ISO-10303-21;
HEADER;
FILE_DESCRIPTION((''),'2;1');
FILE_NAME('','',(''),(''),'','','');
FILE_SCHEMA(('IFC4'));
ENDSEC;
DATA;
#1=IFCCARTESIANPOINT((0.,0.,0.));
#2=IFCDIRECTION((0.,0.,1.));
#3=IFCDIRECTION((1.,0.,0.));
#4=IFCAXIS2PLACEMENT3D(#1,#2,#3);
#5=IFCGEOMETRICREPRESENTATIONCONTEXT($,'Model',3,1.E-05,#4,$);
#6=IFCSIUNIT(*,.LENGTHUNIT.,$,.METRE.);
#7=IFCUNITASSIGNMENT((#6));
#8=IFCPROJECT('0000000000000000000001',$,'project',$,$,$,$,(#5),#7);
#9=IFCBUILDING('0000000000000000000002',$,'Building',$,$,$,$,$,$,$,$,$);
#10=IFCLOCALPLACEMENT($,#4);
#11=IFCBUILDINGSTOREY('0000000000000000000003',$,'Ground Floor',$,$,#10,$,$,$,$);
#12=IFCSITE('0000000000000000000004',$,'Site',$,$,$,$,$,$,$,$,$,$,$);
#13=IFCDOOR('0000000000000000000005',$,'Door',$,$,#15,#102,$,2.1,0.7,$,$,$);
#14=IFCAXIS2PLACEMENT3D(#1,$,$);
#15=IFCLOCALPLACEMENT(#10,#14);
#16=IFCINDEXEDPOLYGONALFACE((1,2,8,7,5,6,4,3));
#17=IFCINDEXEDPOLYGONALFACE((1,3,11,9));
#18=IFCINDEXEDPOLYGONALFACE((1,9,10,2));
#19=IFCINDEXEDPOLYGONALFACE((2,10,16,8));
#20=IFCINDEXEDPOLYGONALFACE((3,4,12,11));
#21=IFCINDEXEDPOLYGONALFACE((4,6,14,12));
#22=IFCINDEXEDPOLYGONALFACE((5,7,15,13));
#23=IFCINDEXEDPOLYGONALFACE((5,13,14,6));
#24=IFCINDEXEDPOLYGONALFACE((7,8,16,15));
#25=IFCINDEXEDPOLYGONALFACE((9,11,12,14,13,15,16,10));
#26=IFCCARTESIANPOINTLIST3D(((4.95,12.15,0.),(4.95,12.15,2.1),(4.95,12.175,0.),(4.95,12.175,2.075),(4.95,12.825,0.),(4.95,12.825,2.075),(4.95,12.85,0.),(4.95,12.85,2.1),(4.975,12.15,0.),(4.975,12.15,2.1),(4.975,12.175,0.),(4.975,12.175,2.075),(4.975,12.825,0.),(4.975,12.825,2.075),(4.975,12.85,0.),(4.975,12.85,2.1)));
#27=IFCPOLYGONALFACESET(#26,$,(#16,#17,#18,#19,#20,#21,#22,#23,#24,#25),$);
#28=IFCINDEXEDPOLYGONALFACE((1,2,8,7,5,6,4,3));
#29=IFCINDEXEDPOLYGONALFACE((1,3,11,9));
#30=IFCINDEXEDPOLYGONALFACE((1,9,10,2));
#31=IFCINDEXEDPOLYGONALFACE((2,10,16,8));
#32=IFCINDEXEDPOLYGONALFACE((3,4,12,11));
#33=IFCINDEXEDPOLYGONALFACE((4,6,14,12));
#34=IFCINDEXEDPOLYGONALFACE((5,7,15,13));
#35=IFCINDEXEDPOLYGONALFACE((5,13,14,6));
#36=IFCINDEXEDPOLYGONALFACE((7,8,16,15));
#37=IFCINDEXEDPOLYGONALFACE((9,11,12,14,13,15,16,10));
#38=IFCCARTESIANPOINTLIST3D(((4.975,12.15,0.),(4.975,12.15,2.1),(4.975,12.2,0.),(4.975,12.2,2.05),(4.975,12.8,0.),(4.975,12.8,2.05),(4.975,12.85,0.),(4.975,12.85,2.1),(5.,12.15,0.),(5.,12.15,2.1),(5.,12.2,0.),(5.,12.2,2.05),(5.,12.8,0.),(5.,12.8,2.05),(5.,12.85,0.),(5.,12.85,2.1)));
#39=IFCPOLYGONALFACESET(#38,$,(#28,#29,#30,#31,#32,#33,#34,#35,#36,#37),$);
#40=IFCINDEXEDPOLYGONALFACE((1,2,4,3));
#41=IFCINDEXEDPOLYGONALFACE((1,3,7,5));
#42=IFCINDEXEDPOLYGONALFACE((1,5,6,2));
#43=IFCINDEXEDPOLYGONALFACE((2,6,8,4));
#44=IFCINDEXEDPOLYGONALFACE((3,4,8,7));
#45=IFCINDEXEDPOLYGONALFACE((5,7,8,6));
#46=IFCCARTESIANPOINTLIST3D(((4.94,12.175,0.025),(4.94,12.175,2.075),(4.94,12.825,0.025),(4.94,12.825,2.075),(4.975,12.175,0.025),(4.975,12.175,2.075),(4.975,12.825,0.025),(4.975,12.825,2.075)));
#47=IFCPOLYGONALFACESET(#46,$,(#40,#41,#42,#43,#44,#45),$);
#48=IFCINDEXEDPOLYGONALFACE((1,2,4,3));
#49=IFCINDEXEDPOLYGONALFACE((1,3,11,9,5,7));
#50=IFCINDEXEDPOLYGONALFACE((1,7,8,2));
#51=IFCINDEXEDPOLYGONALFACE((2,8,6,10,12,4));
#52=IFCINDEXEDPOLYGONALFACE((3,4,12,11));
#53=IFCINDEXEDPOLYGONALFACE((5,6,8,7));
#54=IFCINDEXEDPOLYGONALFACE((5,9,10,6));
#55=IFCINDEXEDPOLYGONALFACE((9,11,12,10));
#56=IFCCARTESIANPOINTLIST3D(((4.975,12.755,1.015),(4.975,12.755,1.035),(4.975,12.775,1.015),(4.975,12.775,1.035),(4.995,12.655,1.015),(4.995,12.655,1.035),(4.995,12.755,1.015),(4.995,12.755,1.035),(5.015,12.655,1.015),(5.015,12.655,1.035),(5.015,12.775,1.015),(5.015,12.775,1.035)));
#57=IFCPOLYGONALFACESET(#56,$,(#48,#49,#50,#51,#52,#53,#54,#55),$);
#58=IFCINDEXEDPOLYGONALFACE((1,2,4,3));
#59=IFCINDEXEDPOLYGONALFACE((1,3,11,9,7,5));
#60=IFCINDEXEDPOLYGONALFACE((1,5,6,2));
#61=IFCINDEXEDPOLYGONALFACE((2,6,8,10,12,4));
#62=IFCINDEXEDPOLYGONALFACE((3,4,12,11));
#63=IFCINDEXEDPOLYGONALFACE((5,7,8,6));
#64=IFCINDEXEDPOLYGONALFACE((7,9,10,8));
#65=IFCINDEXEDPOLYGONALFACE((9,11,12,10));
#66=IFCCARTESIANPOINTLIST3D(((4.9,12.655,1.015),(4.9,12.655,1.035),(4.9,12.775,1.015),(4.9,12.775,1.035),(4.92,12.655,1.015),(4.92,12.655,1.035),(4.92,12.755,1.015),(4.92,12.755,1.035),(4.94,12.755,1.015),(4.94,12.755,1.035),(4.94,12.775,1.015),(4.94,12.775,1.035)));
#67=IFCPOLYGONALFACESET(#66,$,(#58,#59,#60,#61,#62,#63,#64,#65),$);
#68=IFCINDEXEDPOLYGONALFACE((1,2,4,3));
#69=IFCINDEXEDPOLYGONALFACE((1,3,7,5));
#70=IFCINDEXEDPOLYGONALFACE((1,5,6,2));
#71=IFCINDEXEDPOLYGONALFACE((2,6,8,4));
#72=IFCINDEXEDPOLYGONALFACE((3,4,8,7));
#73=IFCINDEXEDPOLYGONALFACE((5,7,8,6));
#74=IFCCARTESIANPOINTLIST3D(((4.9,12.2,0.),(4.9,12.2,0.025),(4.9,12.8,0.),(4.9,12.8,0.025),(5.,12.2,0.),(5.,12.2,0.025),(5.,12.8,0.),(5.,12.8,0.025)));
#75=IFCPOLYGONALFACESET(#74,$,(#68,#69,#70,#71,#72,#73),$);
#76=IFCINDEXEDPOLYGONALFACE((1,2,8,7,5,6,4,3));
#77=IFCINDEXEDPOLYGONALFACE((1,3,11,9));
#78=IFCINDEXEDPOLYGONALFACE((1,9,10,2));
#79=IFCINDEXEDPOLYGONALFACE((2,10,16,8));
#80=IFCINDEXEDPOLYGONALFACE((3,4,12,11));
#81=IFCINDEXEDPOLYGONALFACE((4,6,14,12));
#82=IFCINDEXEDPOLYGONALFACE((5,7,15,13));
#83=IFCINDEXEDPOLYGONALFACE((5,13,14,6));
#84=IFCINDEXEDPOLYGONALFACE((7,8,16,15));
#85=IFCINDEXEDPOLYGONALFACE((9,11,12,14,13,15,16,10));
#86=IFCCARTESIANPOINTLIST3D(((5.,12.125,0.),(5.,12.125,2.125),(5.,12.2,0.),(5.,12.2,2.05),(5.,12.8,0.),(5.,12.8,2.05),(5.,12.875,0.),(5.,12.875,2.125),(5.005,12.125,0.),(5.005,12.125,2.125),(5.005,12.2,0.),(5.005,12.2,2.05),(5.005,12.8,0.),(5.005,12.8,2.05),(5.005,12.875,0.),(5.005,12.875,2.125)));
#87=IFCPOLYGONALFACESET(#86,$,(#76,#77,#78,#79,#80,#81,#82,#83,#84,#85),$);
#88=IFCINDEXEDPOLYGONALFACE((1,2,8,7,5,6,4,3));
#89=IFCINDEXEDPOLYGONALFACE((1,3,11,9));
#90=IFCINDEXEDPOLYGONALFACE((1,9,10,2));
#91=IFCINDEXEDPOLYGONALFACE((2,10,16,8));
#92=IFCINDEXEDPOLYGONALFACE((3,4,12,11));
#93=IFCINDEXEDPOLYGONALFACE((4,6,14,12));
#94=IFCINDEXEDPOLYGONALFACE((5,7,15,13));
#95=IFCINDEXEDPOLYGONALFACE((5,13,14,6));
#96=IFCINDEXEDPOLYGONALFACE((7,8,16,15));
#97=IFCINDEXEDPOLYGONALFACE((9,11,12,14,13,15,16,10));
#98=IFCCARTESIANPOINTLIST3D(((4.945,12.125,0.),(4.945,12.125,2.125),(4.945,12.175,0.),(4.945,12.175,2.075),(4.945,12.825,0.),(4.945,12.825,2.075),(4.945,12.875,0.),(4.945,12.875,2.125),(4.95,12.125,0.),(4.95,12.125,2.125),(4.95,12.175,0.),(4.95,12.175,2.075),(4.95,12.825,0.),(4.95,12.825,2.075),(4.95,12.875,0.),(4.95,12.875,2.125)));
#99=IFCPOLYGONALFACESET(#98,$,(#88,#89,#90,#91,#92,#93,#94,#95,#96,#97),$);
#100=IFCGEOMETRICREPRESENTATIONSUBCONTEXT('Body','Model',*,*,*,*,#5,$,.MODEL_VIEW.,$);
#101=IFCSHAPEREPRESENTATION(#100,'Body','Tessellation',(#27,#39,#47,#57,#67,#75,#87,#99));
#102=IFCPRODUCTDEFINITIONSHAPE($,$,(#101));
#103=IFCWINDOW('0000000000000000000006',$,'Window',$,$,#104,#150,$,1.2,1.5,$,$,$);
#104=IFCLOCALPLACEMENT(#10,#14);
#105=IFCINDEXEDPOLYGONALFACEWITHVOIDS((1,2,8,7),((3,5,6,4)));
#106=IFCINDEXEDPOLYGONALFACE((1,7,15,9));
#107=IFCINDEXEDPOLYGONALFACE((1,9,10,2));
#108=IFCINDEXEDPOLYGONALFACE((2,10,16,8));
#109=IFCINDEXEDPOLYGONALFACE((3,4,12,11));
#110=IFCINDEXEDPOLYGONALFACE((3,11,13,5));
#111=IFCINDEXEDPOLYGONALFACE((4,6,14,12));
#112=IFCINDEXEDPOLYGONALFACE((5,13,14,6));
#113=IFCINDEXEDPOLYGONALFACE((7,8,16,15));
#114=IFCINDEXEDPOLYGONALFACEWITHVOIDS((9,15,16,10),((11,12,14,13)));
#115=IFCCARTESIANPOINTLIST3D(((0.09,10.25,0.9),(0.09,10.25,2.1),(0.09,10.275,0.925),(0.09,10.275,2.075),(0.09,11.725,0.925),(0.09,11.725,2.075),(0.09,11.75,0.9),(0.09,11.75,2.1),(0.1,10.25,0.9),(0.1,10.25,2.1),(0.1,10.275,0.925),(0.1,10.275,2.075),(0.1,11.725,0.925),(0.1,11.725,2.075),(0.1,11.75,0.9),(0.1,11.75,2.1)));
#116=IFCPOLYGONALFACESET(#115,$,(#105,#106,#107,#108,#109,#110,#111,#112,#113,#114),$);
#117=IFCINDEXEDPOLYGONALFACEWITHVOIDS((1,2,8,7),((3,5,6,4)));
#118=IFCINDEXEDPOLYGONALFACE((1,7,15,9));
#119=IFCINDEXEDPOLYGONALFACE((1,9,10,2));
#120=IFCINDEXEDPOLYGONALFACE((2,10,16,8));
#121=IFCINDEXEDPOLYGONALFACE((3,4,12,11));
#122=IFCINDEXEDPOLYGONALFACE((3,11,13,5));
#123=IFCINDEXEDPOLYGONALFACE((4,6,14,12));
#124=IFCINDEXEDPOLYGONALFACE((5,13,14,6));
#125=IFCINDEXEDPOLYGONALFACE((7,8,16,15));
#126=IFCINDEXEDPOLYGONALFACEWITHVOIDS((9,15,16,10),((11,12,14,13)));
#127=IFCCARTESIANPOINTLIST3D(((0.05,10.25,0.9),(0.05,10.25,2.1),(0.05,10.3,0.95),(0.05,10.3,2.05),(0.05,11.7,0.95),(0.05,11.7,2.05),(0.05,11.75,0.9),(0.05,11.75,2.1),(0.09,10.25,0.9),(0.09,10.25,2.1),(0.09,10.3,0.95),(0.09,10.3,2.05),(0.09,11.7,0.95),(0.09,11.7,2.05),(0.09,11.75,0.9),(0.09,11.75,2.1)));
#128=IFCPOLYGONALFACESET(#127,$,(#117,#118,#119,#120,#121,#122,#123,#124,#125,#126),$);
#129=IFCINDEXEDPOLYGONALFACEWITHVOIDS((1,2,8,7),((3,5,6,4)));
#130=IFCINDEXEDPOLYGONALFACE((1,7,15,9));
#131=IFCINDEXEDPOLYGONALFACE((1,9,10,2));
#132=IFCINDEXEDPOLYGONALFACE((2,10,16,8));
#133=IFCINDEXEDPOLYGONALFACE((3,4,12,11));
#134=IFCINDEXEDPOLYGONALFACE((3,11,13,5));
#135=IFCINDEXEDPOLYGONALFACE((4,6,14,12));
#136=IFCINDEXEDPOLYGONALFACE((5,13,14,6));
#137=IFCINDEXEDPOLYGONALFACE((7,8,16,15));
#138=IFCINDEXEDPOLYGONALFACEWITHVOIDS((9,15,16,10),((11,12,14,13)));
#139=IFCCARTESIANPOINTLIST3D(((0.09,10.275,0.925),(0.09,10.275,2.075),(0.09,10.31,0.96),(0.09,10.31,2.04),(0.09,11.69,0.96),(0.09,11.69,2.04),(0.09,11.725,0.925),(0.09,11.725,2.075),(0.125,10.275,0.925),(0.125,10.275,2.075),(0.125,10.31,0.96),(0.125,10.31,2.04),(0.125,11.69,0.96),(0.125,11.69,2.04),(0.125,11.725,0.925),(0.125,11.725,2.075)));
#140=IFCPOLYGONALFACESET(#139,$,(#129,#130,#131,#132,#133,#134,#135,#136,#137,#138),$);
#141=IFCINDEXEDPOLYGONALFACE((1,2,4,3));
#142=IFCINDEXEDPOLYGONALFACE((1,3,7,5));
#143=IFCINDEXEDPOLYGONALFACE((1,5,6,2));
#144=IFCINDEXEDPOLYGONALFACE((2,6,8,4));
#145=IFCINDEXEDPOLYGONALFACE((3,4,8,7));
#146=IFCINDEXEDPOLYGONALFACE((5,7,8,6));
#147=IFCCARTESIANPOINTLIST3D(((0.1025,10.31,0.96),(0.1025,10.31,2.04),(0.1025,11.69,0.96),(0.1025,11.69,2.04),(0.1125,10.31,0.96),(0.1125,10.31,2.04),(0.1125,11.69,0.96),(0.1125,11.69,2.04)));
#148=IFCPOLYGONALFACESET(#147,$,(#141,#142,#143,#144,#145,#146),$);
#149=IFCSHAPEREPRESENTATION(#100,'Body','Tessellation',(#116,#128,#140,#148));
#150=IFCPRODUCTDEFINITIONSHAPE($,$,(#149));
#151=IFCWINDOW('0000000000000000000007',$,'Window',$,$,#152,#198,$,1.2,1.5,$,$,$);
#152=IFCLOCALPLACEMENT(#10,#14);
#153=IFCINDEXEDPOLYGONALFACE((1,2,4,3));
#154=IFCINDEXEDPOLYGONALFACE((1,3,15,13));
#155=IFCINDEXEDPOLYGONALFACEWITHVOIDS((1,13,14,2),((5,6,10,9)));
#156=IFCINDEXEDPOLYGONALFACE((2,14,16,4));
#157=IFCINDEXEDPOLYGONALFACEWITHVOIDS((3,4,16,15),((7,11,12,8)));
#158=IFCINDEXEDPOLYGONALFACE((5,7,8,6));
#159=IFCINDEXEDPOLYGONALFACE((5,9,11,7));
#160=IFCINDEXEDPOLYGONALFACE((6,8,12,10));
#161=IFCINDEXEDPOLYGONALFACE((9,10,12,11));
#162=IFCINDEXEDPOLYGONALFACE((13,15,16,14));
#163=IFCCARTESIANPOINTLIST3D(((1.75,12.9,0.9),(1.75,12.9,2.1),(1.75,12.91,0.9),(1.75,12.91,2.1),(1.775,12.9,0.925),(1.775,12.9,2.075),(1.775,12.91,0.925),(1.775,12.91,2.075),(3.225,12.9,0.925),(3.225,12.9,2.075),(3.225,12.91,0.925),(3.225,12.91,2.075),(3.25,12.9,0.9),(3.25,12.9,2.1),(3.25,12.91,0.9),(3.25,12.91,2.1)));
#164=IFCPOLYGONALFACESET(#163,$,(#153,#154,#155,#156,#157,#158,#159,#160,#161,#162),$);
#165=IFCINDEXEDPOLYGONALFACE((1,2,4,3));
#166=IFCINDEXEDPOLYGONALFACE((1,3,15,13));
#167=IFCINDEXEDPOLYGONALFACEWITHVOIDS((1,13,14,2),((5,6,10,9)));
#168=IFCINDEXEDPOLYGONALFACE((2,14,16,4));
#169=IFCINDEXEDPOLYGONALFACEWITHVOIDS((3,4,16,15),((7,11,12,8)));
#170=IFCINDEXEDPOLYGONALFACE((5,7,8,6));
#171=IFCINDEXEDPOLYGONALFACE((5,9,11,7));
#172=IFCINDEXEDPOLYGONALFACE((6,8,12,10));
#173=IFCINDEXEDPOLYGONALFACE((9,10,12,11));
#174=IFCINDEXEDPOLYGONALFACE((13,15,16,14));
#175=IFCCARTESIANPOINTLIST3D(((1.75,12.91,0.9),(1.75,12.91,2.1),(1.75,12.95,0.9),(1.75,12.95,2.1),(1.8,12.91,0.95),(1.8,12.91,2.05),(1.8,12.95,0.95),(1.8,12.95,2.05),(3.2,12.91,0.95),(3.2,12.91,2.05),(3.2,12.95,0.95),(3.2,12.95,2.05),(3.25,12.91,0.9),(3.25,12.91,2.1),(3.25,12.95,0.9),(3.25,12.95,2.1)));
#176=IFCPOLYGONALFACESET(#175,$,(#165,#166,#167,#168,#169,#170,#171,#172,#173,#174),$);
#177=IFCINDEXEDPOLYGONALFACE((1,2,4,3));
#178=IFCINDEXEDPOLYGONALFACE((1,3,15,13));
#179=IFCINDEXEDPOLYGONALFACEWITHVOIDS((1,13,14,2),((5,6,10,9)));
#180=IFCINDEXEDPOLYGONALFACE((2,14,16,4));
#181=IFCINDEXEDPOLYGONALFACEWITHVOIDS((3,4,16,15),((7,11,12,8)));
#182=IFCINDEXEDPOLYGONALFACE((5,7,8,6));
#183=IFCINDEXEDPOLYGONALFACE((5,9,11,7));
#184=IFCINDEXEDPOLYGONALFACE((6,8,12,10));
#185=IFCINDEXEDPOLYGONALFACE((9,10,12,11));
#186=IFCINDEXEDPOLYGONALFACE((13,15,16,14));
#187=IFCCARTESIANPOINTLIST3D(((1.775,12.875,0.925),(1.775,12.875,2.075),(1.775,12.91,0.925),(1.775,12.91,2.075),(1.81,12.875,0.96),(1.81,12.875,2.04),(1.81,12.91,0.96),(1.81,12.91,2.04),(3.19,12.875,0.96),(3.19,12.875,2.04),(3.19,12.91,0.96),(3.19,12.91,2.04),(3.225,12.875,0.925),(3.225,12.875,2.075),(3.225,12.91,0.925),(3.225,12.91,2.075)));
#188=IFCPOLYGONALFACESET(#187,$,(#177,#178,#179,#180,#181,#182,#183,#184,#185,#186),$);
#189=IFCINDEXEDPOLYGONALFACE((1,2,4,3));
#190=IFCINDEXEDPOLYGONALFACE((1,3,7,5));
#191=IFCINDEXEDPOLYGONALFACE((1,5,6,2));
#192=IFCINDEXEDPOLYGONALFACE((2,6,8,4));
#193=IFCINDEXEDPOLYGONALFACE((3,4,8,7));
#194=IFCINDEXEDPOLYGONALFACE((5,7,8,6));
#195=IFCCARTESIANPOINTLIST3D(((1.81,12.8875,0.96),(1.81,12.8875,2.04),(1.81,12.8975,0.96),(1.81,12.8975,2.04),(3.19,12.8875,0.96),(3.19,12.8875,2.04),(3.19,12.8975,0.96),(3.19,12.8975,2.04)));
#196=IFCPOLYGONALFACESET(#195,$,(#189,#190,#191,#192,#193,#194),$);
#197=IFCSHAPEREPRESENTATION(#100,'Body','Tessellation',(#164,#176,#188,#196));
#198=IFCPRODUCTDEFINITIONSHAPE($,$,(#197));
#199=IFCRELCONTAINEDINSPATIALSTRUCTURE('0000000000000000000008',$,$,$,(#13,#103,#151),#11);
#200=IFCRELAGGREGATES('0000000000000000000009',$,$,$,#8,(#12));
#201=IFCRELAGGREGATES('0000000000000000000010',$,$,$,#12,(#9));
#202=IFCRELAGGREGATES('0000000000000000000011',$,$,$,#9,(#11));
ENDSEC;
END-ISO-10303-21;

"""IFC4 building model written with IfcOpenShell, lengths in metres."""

from ifc_helpers import new_model, si_unit, frame, origin_with_axes, place, context, subcontext, project, spatial, line, indexed_curve, outline, extrude, element, save


model = new_model("IFC4")

# Units and contexts
model_context = context("Model", 3, precision=1e-05, world=origin_with_axes())
body_context = subcontext(model_context, "Body", "Model", "MODEL_VIEW")
ifc_project = project(units=[si_unit("LENGTHUNIT", "METRE")], contexts=[model_context])

# Site, building, storey
site = spatial("IfcSite", under=ifc_project, Name="Site")
building = spatial("IfcBuilding", under=site, Name="Building")
storey_placement = place(None, origin_with_axes())
storey = spatial("IfcBuildingStorey", under=building, at=storey_placement, Name="Ground Floor")

# Door
door_1_placement = place(storey_placement, frame((5.0, 12.15, 0.0), z_axis=(0.0, 0.0, 1.0), x_axis=(0.0, 1.0, 0.0)))
element("IfcDoor", 1, at=door_1_placement, inside=storey, Name="Door", OverallHeight=2.1, OverallWidth=0.7, context=body_context, shape_type="SweptSolid", body=[
    extrude(outline(indexed_curve([(0.0, 0.0), (0.0, 2.1), (0.7, 2.1), (0.7, 0.0), (0.675, 0.0), (0.675, 2.075), (0.025, 2.075), (0.025, 0.0)], segments=[line(1, 2, 3, 4, 5, 6, 7, 8, 1)])), frame((0.0, 0.025, 0.0), z_axis=(0.0, -1.0, 0.0), x_axis=(1.0, 0.0, 0.0)), (0.0, 0.0, -1.0), 0.025),
    extrude(outline(indexed_curve([(0.0, 0.0), (0.0, 2.1), (0.7, 2.1), (0.7, 0.0), (0.65, 0.0), (0.65, 2.05), (0.05, 2.05), (0.05, 0.0)], segments=[line(1, 2, 3, 4, 5, 6, 7, 8, 1)])), frame((0.0, 0.0, 0.0), z_axis=(0.0, -1.0, 0.0), x_axis=(1.0, 0.0, 0.0)), (0.0, 0.0, -1.0), 0.025),
    extrude(outline(indexed_curve([(0.0, 0.0), (0.65, 0.0), (0.65, 0.035), (0.0, 0.035)], segments=[line(1, 2, 3, 4, 1)])), frame((0.025, 0.025, 0.025), z_axis=(0.0, 0.0, 1.0), x_axis=(1.0, 0.0, 0.0)), (0.0, 0.0, 1.0), 2.05),
    extrude(outline(indexed_curve([(0.0, 0.0), (0.0, -0.04), (-0.12, -0.04), (-0.12, -0.02), (-0.02, -0.02), (-0.02, 0.0)], segments=[line(1, 2, 3, 4, 5, 6, 1)])), frame((0.625, 0.025, 1.015), z_axis=(0.0, 0.0, 1.0), x_axis=(1.0, 0.0, 0.0)), (0.0, 0.0, 1.0), 0.02),
    extrude(outline(indexed_curve([(0.0, 0.0), (0.0, 0.04), (-0.12, 0.04), (-0.12, 0.02), (-0.02, 0.02), (-0.02, 0.0)], segments=[line(1, 2, 3, 4, 5, 6, 1)])), frame((0.625, 0.06, 1.015), z_axis=(0.0, 0.0, 1.0), x_axis=(1.0, 0.0, 0.0)), (0.0, 0.0, 1.0), 0.02),
    extrude(outline(indexed_curve([(0.0, 0.0), (0.6, 0.0), (0.6, 0.1), (0.0, 0.1)], segments=[line(1, 2, 3, 4, 1)])), frame((0.05, 0.0, 0.0), z_axis=(0.0, 0.0, 1.0), x_axis=(1.0, 0.0, 0.0)), (0.0, 0.0, 1.0), 0.025),
    extrude(outline(indexed_curve([(0.0, 0.0), (0.0, 2.125), (0.75, 2.125), (0.75, 0.0), (0.675, 0.0), (0.675, 2.05), (0.075, 2.05), (0.075, 0.0)], segments=[line(1, 2, 3, 4, 5, 6, 7, 8, 1)])), frame((-0.025, -0.005, 0.0), z_axis=(0.0, -1.0, 0.0), x_axis=(1.0, 0.0, 0.0)), (0.0, 0.0, -1.0), 0.005),
    extrude(outline(indexed_curve([(0.0, 0.0), (0.0, 2.125), (0.75, 2.125), (0.75, 0.0), (0.7, 0.0), (0.7, 2.075), (0.05, 2.075), (0.05, 0.0)], segments=[line(1, 2, 3, 4, 5, 6, 7, 8, 1)])), frame((-0.025, 0.05, 0.0), z_axis=(0.0, -1.0, 0.0), x_axis=(1.0, 0.0, 0.0)), (0.0, 0.0, -1.0), 0.005),
])

# Windows
for number, where, z_axis, x_axis, name in (
    (2, (0.0, 11.75, 0.9), (0.0, 0.0, 1.0), (0.0, -1.0, 0.0), "Window"),
    (3, (3.25, 13.0, 0.9), (0.0, 0.0, 1.0), (-1.0, 0.0, 0.0), "Window"),
):
    element("IfcWindow", number, at=place(storey_placement, frame(where, z_axis=z_axis, x_axis=x_axis)), inside=storey, Name=name, OverallHeight=1.2, OverallWidth=1.5, context=body_context, shape_type="SweptSolid", body=[
        extrude(outline(indexed_curve([(0.0, 0.0), (1.5, 0.0), (1.5, 1.2), (0.0, 1.2)], segments=[line(1, 2, 3, 4, 1)]), holes=[indexed_curve([(0.025, 0.025), (1.475, 0.025), (1.475, 1.175), (0.025, 1.175)], segments=[line(1, 2, 3, 4, 1)])]), frame((0.0, 0.09, 0.0), z_axis=(0.0, -1.0, 0.0), x_axis=(1.0, 0.0, 0.0)), (0.0, 0.0, -1.0), 0.01),
        extrude(outline(indexed_curve([(0.0, 0.0), (1.5, 0.0), (1.5, 1.2), (0.0, 1.2)], segments=[line(1, 2, 3, 4, 1)]), holes=[indexed_curve([(0.05, 0.05), (1.45, 0.05), (1.45, 1.15), (0.05, 1.15)], segments=[line(1, 2, 3, 4, 1)])]), frame((0.0, 0.05, 0.0), z_axis=(0.0, -1.0, 0.0), x_axis=(1.0, 0.0, 0.0)), (0.0, 0.0, -1.0), 0.04),
        extrude(outline(indexed_curve([(0.0, 0.0), (1.45, 0.0), (1.45, 1.15), (0.0, 1.15)], segments=[line(1, 2, 3, 4, 1)]), holes=[indexed_curve([(0.035, 0.035), (1.415, 0.035), (1.415, 1.115), (0.035, 1.115)], segments=[line(1, 2, 3, 4, 1)])]), frame((0.025, 0.09, 0.025), z_axis=(0.0, -1.0, 0.0), x_axis=(1.0, 0.0, 0.0)), (0.0, 0.0, -1.0), 0.035),
        extrude(outline(indexed_curve([(0.035, 0.035), (1.415, 0.035), (1.415, 1.115), (0.035, 1.115)], segments=[line(1, 2, 3, 4, 1)])), frame((0.025, 0.1025, 0.025), z_axis=(0.0, -1.0, 0.0), x_axis=(1.0, 0.0, 0.0)), (0.0, 0.0, -1.0), 0.01),
    ])

save(model, "model.ifc")
